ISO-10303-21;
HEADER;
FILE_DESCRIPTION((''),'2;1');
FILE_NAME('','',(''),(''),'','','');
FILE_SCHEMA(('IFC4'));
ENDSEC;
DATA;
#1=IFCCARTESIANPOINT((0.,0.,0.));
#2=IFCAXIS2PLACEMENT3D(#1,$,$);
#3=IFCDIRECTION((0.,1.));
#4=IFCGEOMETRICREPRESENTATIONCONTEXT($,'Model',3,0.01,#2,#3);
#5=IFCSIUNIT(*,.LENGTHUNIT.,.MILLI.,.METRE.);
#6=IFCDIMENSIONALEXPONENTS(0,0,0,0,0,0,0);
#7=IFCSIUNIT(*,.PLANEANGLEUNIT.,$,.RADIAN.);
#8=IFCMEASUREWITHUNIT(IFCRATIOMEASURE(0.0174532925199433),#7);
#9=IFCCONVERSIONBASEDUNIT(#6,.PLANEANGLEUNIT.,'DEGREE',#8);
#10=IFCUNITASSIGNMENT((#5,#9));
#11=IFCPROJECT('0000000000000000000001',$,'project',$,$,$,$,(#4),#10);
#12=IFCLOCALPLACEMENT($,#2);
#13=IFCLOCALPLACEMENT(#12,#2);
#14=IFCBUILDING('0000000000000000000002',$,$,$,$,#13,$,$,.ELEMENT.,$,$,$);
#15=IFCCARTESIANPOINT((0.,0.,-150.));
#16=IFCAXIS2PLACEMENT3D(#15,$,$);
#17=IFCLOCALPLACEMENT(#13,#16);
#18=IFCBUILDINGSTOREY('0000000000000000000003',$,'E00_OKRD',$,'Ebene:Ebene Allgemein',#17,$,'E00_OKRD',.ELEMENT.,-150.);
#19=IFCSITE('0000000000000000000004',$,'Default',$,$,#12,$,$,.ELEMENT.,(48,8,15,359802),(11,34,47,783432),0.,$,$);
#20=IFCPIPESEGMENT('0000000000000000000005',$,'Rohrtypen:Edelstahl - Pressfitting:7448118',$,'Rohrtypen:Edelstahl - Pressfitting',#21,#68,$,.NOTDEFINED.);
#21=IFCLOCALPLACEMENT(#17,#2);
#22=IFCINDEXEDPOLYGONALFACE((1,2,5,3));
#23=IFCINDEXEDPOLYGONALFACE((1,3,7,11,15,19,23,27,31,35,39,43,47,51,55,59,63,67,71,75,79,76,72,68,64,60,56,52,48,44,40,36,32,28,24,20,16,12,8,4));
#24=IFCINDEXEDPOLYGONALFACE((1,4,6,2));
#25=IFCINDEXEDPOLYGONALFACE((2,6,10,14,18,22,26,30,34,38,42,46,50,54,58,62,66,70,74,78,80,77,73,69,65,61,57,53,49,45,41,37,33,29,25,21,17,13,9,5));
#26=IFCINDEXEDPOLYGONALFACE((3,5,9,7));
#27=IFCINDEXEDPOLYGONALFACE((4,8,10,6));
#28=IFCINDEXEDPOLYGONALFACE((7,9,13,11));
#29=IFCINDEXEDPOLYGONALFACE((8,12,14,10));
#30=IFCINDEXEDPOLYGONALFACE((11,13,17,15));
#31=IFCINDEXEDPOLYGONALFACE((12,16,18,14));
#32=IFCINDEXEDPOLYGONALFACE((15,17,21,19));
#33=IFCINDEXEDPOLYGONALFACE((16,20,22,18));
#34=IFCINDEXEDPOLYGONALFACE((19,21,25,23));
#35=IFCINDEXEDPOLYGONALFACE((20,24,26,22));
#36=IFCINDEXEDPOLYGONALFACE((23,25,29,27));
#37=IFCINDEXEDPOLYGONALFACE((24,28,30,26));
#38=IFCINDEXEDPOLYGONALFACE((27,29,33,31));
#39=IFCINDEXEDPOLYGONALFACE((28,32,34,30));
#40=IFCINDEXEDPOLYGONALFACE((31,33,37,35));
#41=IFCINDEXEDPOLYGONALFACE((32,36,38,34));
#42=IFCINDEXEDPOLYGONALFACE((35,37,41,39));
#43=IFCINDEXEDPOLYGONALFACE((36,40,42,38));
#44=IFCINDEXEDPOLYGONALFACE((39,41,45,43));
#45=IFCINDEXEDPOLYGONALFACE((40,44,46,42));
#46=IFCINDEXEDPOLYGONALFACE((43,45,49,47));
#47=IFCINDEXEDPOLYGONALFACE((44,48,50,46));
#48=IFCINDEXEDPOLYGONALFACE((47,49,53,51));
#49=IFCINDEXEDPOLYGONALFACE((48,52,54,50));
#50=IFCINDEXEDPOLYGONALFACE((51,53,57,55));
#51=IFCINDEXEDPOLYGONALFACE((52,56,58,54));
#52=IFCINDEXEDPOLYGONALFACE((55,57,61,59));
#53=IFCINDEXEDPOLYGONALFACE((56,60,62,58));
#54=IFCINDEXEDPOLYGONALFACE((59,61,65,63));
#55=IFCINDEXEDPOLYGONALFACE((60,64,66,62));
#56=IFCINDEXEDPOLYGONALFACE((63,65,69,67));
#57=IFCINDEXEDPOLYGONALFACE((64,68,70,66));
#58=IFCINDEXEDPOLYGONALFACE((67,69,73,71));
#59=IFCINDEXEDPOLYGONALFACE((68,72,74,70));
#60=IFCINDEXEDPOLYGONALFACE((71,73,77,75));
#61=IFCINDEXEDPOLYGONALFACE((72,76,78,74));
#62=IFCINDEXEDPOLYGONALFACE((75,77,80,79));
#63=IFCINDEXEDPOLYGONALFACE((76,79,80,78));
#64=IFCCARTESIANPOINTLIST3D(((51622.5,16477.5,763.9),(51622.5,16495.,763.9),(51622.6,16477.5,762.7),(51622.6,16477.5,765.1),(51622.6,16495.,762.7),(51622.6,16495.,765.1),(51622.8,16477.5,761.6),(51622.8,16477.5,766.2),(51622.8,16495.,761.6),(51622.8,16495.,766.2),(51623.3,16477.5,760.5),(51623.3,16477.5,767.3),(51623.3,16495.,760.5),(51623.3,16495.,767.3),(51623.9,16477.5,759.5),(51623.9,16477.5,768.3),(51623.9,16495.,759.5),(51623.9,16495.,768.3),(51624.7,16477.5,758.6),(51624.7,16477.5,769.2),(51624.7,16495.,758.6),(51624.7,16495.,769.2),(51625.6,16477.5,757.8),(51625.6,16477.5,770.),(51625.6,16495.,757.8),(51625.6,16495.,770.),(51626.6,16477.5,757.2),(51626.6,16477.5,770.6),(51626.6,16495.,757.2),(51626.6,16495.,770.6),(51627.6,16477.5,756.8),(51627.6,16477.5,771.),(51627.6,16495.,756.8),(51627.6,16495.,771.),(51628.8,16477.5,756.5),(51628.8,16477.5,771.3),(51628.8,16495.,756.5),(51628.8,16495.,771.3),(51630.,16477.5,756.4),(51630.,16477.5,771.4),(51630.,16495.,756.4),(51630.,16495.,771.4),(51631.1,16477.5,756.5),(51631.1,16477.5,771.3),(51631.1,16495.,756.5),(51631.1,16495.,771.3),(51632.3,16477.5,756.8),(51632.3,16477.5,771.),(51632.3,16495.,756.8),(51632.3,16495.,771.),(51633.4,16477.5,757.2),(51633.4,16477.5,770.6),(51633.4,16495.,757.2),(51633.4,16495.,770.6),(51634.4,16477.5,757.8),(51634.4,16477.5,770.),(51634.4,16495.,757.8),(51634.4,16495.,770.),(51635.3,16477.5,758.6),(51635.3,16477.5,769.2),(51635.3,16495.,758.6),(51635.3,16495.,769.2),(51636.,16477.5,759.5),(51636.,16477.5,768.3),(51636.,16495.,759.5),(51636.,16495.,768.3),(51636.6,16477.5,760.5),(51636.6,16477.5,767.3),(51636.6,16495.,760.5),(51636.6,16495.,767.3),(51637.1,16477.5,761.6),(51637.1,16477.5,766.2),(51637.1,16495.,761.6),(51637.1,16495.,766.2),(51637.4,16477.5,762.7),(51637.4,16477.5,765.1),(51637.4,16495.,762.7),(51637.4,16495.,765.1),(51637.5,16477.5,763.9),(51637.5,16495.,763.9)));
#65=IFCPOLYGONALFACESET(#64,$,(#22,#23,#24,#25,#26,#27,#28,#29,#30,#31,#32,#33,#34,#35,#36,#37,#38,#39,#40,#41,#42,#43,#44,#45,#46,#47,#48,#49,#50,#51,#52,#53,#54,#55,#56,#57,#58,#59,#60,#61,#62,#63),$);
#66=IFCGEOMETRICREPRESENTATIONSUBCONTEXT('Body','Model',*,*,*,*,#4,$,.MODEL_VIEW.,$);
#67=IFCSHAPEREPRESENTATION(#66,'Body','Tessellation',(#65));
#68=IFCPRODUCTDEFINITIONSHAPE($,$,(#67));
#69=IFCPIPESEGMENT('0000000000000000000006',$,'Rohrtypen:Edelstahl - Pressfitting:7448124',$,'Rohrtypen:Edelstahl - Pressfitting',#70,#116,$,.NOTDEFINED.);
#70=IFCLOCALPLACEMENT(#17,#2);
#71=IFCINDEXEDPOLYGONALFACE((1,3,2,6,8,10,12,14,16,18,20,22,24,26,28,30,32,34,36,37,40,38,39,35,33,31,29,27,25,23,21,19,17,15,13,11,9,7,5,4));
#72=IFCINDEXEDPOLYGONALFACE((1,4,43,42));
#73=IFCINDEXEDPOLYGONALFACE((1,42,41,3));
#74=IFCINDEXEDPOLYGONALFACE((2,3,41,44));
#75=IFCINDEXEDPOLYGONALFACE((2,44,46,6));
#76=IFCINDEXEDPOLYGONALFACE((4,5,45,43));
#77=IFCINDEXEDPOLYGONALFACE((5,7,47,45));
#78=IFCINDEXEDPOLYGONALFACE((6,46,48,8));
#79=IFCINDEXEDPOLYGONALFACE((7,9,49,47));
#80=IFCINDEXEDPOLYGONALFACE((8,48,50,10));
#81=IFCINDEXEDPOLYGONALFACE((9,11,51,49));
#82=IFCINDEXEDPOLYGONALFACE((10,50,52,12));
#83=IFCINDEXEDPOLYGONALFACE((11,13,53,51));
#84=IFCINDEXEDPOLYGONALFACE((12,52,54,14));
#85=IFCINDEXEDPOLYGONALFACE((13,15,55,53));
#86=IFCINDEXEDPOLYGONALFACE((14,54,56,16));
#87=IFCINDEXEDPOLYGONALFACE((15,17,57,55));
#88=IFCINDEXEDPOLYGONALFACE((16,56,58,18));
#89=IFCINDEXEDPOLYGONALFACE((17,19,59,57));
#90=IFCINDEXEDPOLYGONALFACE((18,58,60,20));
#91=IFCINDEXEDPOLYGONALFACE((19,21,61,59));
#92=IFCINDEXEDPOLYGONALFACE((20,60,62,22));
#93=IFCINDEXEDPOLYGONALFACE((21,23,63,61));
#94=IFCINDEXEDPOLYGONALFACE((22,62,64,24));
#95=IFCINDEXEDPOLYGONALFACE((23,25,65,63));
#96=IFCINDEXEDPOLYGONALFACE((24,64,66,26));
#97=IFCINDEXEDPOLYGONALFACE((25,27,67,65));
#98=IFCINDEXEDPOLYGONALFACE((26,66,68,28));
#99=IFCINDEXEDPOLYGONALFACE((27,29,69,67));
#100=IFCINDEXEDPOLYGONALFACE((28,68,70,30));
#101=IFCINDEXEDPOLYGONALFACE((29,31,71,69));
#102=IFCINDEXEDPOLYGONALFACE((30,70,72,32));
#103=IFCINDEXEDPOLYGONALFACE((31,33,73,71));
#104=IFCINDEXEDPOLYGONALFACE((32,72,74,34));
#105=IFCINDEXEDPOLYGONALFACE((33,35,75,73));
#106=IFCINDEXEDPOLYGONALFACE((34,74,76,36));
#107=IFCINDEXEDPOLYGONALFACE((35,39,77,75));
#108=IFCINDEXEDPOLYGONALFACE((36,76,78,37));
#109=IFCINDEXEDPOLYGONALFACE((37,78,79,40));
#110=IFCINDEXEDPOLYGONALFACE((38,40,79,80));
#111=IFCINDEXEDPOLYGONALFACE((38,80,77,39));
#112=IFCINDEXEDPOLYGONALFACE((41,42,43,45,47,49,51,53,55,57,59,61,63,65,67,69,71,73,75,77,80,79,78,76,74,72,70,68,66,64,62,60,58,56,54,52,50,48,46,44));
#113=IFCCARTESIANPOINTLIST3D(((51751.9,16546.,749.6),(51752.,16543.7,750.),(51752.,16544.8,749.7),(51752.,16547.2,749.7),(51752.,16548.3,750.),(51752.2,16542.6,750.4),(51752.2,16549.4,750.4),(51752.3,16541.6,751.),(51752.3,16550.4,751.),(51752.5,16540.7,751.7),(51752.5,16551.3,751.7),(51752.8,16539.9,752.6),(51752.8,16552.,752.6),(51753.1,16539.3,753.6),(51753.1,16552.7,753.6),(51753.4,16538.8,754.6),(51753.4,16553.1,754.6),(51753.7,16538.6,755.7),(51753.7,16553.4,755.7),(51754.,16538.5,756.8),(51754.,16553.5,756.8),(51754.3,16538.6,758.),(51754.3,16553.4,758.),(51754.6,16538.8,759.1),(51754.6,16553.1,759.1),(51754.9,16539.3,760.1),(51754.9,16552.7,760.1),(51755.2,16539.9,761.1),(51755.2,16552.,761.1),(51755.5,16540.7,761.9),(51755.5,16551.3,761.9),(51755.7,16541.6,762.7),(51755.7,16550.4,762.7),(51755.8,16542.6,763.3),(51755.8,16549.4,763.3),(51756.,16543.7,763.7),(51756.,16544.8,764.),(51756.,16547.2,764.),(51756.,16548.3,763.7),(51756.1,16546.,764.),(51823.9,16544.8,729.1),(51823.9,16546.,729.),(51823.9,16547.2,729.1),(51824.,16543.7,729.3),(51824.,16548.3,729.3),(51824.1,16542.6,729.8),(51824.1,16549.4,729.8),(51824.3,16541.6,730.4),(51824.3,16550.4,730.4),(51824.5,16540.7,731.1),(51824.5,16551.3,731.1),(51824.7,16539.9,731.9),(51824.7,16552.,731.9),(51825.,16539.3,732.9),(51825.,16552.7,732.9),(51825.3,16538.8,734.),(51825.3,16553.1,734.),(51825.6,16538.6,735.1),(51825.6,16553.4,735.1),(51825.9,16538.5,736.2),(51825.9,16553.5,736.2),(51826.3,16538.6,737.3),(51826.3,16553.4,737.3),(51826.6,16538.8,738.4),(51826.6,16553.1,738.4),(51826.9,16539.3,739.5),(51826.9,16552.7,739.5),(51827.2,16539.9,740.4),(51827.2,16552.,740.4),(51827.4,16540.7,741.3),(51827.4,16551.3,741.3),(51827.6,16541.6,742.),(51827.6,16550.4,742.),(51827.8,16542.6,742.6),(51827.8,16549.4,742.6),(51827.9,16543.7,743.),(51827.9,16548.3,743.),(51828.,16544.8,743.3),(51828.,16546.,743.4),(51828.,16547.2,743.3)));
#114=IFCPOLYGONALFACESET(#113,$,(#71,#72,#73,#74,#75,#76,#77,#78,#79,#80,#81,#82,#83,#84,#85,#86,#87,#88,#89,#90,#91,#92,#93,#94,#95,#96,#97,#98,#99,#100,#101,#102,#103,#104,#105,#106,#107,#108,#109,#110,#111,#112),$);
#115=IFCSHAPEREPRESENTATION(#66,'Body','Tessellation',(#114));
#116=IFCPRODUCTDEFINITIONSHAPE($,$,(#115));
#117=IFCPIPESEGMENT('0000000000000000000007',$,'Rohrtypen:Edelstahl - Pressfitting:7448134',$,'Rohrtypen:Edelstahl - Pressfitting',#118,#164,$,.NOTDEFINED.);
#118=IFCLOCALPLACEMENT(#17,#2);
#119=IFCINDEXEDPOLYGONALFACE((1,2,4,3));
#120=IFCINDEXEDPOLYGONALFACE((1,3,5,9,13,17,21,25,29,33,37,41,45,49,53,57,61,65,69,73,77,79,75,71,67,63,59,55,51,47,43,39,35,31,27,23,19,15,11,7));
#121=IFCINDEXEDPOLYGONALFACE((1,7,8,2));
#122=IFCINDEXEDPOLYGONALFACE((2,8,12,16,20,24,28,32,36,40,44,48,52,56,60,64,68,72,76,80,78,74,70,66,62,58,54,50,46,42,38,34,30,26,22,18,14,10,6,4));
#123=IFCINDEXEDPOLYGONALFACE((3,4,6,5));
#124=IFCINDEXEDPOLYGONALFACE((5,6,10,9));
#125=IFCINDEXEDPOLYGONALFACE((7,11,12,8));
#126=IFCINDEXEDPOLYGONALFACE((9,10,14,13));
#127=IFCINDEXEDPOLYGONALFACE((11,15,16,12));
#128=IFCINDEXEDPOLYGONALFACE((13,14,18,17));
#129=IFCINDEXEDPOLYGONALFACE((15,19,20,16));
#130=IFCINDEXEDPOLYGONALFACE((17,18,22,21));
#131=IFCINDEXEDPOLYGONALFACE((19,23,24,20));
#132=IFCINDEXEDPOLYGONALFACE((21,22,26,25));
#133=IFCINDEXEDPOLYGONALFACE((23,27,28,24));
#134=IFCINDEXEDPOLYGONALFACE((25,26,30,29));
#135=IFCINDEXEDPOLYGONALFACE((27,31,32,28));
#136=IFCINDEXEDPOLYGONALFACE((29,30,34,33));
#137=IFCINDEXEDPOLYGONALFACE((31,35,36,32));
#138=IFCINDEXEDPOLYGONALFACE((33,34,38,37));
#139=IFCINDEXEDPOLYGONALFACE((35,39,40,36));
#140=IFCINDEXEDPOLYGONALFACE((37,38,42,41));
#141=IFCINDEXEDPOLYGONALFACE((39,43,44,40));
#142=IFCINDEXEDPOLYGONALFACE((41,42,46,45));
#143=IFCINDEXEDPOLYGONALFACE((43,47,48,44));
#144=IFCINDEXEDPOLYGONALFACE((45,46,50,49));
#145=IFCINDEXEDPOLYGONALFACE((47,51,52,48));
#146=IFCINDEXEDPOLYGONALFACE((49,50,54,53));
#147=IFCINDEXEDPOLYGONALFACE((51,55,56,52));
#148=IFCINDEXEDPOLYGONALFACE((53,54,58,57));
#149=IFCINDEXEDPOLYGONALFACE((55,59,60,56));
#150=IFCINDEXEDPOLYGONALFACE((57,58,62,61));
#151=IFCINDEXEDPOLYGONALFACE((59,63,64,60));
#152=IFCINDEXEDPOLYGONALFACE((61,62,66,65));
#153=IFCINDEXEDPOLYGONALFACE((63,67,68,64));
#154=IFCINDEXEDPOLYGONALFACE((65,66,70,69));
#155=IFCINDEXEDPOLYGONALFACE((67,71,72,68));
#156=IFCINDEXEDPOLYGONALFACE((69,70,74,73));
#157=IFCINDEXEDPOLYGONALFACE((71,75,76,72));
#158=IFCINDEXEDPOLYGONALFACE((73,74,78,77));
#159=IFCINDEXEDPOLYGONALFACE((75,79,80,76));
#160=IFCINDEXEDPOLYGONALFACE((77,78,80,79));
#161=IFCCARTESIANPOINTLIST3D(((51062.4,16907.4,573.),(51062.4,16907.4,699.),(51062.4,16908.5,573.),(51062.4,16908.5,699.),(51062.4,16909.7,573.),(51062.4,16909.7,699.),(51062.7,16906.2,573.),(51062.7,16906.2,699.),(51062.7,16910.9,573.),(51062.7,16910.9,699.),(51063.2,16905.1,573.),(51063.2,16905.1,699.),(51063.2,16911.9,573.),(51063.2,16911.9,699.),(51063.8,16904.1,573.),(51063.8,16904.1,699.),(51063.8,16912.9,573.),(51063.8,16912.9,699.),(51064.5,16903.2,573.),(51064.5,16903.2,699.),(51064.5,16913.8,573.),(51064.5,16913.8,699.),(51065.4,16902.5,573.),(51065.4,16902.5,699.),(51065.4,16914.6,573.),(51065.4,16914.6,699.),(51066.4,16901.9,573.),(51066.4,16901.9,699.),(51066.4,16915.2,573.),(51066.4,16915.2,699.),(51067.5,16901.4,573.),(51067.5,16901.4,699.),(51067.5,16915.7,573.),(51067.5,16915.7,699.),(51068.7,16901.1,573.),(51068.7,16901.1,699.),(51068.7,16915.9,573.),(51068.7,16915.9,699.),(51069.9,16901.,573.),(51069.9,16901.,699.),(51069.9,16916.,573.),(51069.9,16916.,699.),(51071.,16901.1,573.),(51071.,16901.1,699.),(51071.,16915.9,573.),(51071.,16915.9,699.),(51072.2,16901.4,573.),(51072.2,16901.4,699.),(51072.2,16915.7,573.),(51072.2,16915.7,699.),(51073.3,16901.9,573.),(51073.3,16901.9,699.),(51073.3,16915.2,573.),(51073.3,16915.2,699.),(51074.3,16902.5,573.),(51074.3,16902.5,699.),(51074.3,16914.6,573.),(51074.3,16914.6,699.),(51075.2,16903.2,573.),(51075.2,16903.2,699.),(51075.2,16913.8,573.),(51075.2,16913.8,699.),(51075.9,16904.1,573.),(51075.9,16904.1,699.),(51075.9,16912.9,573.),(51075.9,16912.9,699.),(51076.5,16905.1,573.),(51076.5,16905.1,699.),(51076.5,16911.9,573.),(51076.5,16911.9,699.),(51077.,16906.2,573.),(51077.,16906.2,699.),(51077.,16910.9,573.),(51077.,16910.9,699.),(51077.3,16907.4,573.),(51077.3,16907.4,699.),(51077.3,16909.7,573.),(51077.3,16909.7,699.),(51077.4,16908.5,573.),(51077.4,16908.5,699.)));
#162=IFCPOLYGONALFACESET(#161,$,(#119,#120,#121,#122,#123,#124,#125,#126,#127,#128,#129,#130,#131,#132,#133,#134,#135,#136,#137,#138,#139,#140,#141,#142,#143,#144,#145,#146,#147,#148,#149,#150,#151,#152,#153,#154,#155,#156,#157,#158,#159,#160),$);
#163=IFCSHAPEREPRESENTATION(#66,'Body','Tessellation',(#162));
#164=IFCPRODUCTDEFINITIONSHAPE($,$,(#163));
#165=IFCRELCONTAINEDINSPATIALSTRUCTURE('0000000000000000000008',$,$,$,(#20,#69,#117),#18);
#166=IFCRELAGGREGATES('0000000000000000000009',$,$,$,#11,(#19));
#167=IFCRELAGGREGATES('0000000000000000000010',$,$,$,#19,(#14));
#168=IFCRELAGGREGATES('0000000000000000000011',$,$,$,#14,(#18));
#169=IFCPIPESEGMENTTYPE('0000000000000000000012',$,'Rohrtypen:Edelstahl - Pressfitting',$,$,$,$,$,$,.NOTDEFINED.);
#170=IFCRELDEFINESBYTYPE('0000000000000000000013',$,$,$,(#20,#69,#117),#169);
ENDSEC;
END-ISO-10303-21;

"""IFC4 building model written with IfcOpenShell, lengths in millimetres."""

from ifc_helpers import new_model, entity, si_unit, converted_unit, direction, frame, origin, place, context, subcontext, project, spatial, indexed_curve, outline, extrude, type_object, element, save


model = new_model("IFC4")

# Units and contexts
model_context = context("Model", 3, precision=0.01, world=origin(), true_north=direction((0.0, 1.0)))
body_context = subcontext(model_context, "Body", "Model", "MODEL_VIEW")
ifc_project = project(units=[si_unit("LENGTHUNIT", "METRE", prefix="MILLI"), converted_unit("PLANEANGLEUNIT", "DEGREE", entity("IfcRatioMeasure", 0.0174532925199433), si_unit("PLANEANGLEUNIT", "RADIAN"), dimensions=[0, 0, 0, 0, 0, 0, 0])], contexts=[model_context])

# Site, building, storey
site_placement = place(None, origin())
site = spatial("IfcSite", under=ifc_project, at=site_placement, Name="Default", CompositionType="ELEMENT", RefLatitude=(48, 8, 15, 359802), RefLongitude=(11, 34, 47, 783432), RefElevation=0.0)
building_placement = place(site_placement, origin())
building = spatial("IfcBuilding", under=site, at=building_placement, CompositionType="ELEMENT")
storey_placement = place(building_placement, frame((0.0, 0.0, -150.0)))
storey = spatial("IfcBuildingStorey", under=building, at=storey_placement, Name="E00_OKRD", ObjectType="Ebene:Ebene Allgemein", LongName="E00_OKRD", CompositionType="ELEMENT", Elevation=-150.0)

# Pipe segments
pipe_segment_type_1 = type_object("IfcPipeSegmentType", Name="Rohrtypen:Edelstahl - Pressfitting", PredefinedType="NOTDEFINED")
pipe_segment_1_placement = place(storey_placement, origin())
element("IfcPipeSegment", 1, at=pipe_segment_1_placement, inside=storey, type_object=pipe_segment_type_1, Name="Rohrtypen:Edelstahl - Pressfitting:7448118", ObjectType="Rohrtypen:Edelstahl - Pressfitting", PredefinedType="NOTDEFINED", context=body_context, shape_type="SweptSolid", body=[
    extrude(outline(indexed_curve([(7.5, 0.0), (7.4, 1.2), (7.1, 2.3), (6.7, 3.4), (6.1, 4.4), (5.3, 5.3), (4.4, 6.1), (3.4, 6.7), (2.3, 7.1), (1.2, 7.4), (0.0, 7.5), (-1.2, 7.4), (-2.3, 7.1), (-3.4, 6.7), (-4.4, 6.1), (-5.3, 5.3), (-6.1, 4.4), (-6.7, 3.4), (-7.1, 2.3), (-7.4, 1.2), (-7.5, 0.0), (-7.4, -1.2), (-7.1, -2.3), (-6.7, -3.4), (-6.1, -4.4), (-5.3, -5.3), (-4.4, -6.1), (-3.4, -6.7), (-2.3, -7.1), (-1.2, -7.4), (0.0, -7.5), (1.2, -7.4), (2.3, -7.1), (3.4, -6.7), (4.4, -6.1), (5.3, -5.3), (6.1, -4.4), (6.7, -3.4), (7.1, -2.3), (7.4, -1.2), (7.5, 0.0)], self_intersect=False)), frame((51630.0, 16477.5, 763.9), z_axis=(0.0, 1.0, 0.0), x_axis=(1.0, 0.0, 0.0)), (0.0, 0.0, 1.0), 17.4),
])
pipe_segment_2_placement = place(storey_placement, origin())
element("IfcPipeSegment", 2, at=pipe_segment_2_placement, inside=storey, type_object=pipe_segment_type_1, Name="Rohrtypen:Edelstahl - Pressfitting:7448124", ObjectType="Rohrtypen:Edelstahl - Pressfitting", PredefinedType="NOTDEFINED", context=body_context, shape_type="SweptSolid", body=[
    extrude(outline(indexed_curve([(7.5, 0.0), (7.4, 1.2), (7.1, 2.3), (6.7, 3.4), (6.1, 4.4), (5.3, 5.3), (4.4, 6.1), (3.4, 6.7), (2.3, 7.1), (1.2, 7.4), (0.0, 7.5), (-1.2, 7.4), (-2.3, 7.1), (-3.4, 6.7), (-4.4, 6.1), (-5.3, 5.3), (-6.1, 4.4), (-6.7, 3.4), (-7.1, 2.3), (-7.4, 1.2), (-7.5, 0.0), (-7.4, -1.2), (-7.1, -2.3), (-6.7, -3.4), (-6.1, -4.4), (-5.3, -5.3), (-4.4, -6.1), (-3.4, -6.7), (-2.3, -7.1), (-1.2, -7.4), (0.0, -7.5), (1.2, -7.4), (2.3, -7.1), (3.4, -6.7), (4.4, -6.1), (5.3, -5.3), (6.1, -4.4), (6.7, -3.4), (7.1, -2.3), (7.4, -1.2), (7.5, 0.0)], self_intersect=False)), frame((51754.0, 16546.0, 756.8), z_axis=(0.961197, 0.0, -0.275863), x_axis=(0.0, -1.0, 0.0)), (0.0, 0.0, 1.0), 74.8),
])
pipe_segment_3_placement = place(storey_placement, origin())
element("IfcPipeSegment", 3, at=pipe_segment_3_placement, inside=storey, type_object=pipe_segment_type_1, Name="Rohrtypen:Edelstahl - Pressfitting:7448134", ObjectType="Rohrtypen:Edelstahl - Pressfitting", PredefinedType="NOTDEFINED", context=body_context, shape_type="SweptSolid", body=[
    extrude(outline(indexed_curve([(7.5, 0.0), (7.4, 1.2), (7.1, 2.3), (6.7, 3.4), (6.1, 4.4), (5.3, 5.3), (4.4, 6.1), (3.4, 6.7), (2.3, 7.1), (1.2, 7.4), (0.0, 7.5), (-1.2, 7.4), (-2.3, 7.1), (-3.4, 6.7), (-4.4, 6.1), (-5.3, 5.3), (-6.1, 4.4), (-6.7, 3.4), (-7.1, 2.3), (-7.4, 1.2), (-7.5, 0.0), (-7.4, -1.2), (-7.1, -2.3), (-6.7, -3.4), (-6.1, -4.4), (-5.3, -5.3), (-4.4, -6.1), (-3.4, -6.7), (-2.3, -7.1), (-1.2, -7.4), (0.0, -7.5), (1.2, -7.4), (2.3, -7.1), (3.4, -6.7), (4.4, -6.1), (5.3, -5.3), (6.1, -4.4), (6.7, -3.4), (7.1, -2.3), (7.4, -1.2), (7.5, 0.0)], self_intersect=False)), frame((51069.9, 16908.5, 573.0), z_axis=(0.0, 0.0, 1.0), x_axis=(-1.0, 0.0, 0.0)), (0.0, 0.0, 1.0), 126.0),
])

save(model, "model.ifc")
